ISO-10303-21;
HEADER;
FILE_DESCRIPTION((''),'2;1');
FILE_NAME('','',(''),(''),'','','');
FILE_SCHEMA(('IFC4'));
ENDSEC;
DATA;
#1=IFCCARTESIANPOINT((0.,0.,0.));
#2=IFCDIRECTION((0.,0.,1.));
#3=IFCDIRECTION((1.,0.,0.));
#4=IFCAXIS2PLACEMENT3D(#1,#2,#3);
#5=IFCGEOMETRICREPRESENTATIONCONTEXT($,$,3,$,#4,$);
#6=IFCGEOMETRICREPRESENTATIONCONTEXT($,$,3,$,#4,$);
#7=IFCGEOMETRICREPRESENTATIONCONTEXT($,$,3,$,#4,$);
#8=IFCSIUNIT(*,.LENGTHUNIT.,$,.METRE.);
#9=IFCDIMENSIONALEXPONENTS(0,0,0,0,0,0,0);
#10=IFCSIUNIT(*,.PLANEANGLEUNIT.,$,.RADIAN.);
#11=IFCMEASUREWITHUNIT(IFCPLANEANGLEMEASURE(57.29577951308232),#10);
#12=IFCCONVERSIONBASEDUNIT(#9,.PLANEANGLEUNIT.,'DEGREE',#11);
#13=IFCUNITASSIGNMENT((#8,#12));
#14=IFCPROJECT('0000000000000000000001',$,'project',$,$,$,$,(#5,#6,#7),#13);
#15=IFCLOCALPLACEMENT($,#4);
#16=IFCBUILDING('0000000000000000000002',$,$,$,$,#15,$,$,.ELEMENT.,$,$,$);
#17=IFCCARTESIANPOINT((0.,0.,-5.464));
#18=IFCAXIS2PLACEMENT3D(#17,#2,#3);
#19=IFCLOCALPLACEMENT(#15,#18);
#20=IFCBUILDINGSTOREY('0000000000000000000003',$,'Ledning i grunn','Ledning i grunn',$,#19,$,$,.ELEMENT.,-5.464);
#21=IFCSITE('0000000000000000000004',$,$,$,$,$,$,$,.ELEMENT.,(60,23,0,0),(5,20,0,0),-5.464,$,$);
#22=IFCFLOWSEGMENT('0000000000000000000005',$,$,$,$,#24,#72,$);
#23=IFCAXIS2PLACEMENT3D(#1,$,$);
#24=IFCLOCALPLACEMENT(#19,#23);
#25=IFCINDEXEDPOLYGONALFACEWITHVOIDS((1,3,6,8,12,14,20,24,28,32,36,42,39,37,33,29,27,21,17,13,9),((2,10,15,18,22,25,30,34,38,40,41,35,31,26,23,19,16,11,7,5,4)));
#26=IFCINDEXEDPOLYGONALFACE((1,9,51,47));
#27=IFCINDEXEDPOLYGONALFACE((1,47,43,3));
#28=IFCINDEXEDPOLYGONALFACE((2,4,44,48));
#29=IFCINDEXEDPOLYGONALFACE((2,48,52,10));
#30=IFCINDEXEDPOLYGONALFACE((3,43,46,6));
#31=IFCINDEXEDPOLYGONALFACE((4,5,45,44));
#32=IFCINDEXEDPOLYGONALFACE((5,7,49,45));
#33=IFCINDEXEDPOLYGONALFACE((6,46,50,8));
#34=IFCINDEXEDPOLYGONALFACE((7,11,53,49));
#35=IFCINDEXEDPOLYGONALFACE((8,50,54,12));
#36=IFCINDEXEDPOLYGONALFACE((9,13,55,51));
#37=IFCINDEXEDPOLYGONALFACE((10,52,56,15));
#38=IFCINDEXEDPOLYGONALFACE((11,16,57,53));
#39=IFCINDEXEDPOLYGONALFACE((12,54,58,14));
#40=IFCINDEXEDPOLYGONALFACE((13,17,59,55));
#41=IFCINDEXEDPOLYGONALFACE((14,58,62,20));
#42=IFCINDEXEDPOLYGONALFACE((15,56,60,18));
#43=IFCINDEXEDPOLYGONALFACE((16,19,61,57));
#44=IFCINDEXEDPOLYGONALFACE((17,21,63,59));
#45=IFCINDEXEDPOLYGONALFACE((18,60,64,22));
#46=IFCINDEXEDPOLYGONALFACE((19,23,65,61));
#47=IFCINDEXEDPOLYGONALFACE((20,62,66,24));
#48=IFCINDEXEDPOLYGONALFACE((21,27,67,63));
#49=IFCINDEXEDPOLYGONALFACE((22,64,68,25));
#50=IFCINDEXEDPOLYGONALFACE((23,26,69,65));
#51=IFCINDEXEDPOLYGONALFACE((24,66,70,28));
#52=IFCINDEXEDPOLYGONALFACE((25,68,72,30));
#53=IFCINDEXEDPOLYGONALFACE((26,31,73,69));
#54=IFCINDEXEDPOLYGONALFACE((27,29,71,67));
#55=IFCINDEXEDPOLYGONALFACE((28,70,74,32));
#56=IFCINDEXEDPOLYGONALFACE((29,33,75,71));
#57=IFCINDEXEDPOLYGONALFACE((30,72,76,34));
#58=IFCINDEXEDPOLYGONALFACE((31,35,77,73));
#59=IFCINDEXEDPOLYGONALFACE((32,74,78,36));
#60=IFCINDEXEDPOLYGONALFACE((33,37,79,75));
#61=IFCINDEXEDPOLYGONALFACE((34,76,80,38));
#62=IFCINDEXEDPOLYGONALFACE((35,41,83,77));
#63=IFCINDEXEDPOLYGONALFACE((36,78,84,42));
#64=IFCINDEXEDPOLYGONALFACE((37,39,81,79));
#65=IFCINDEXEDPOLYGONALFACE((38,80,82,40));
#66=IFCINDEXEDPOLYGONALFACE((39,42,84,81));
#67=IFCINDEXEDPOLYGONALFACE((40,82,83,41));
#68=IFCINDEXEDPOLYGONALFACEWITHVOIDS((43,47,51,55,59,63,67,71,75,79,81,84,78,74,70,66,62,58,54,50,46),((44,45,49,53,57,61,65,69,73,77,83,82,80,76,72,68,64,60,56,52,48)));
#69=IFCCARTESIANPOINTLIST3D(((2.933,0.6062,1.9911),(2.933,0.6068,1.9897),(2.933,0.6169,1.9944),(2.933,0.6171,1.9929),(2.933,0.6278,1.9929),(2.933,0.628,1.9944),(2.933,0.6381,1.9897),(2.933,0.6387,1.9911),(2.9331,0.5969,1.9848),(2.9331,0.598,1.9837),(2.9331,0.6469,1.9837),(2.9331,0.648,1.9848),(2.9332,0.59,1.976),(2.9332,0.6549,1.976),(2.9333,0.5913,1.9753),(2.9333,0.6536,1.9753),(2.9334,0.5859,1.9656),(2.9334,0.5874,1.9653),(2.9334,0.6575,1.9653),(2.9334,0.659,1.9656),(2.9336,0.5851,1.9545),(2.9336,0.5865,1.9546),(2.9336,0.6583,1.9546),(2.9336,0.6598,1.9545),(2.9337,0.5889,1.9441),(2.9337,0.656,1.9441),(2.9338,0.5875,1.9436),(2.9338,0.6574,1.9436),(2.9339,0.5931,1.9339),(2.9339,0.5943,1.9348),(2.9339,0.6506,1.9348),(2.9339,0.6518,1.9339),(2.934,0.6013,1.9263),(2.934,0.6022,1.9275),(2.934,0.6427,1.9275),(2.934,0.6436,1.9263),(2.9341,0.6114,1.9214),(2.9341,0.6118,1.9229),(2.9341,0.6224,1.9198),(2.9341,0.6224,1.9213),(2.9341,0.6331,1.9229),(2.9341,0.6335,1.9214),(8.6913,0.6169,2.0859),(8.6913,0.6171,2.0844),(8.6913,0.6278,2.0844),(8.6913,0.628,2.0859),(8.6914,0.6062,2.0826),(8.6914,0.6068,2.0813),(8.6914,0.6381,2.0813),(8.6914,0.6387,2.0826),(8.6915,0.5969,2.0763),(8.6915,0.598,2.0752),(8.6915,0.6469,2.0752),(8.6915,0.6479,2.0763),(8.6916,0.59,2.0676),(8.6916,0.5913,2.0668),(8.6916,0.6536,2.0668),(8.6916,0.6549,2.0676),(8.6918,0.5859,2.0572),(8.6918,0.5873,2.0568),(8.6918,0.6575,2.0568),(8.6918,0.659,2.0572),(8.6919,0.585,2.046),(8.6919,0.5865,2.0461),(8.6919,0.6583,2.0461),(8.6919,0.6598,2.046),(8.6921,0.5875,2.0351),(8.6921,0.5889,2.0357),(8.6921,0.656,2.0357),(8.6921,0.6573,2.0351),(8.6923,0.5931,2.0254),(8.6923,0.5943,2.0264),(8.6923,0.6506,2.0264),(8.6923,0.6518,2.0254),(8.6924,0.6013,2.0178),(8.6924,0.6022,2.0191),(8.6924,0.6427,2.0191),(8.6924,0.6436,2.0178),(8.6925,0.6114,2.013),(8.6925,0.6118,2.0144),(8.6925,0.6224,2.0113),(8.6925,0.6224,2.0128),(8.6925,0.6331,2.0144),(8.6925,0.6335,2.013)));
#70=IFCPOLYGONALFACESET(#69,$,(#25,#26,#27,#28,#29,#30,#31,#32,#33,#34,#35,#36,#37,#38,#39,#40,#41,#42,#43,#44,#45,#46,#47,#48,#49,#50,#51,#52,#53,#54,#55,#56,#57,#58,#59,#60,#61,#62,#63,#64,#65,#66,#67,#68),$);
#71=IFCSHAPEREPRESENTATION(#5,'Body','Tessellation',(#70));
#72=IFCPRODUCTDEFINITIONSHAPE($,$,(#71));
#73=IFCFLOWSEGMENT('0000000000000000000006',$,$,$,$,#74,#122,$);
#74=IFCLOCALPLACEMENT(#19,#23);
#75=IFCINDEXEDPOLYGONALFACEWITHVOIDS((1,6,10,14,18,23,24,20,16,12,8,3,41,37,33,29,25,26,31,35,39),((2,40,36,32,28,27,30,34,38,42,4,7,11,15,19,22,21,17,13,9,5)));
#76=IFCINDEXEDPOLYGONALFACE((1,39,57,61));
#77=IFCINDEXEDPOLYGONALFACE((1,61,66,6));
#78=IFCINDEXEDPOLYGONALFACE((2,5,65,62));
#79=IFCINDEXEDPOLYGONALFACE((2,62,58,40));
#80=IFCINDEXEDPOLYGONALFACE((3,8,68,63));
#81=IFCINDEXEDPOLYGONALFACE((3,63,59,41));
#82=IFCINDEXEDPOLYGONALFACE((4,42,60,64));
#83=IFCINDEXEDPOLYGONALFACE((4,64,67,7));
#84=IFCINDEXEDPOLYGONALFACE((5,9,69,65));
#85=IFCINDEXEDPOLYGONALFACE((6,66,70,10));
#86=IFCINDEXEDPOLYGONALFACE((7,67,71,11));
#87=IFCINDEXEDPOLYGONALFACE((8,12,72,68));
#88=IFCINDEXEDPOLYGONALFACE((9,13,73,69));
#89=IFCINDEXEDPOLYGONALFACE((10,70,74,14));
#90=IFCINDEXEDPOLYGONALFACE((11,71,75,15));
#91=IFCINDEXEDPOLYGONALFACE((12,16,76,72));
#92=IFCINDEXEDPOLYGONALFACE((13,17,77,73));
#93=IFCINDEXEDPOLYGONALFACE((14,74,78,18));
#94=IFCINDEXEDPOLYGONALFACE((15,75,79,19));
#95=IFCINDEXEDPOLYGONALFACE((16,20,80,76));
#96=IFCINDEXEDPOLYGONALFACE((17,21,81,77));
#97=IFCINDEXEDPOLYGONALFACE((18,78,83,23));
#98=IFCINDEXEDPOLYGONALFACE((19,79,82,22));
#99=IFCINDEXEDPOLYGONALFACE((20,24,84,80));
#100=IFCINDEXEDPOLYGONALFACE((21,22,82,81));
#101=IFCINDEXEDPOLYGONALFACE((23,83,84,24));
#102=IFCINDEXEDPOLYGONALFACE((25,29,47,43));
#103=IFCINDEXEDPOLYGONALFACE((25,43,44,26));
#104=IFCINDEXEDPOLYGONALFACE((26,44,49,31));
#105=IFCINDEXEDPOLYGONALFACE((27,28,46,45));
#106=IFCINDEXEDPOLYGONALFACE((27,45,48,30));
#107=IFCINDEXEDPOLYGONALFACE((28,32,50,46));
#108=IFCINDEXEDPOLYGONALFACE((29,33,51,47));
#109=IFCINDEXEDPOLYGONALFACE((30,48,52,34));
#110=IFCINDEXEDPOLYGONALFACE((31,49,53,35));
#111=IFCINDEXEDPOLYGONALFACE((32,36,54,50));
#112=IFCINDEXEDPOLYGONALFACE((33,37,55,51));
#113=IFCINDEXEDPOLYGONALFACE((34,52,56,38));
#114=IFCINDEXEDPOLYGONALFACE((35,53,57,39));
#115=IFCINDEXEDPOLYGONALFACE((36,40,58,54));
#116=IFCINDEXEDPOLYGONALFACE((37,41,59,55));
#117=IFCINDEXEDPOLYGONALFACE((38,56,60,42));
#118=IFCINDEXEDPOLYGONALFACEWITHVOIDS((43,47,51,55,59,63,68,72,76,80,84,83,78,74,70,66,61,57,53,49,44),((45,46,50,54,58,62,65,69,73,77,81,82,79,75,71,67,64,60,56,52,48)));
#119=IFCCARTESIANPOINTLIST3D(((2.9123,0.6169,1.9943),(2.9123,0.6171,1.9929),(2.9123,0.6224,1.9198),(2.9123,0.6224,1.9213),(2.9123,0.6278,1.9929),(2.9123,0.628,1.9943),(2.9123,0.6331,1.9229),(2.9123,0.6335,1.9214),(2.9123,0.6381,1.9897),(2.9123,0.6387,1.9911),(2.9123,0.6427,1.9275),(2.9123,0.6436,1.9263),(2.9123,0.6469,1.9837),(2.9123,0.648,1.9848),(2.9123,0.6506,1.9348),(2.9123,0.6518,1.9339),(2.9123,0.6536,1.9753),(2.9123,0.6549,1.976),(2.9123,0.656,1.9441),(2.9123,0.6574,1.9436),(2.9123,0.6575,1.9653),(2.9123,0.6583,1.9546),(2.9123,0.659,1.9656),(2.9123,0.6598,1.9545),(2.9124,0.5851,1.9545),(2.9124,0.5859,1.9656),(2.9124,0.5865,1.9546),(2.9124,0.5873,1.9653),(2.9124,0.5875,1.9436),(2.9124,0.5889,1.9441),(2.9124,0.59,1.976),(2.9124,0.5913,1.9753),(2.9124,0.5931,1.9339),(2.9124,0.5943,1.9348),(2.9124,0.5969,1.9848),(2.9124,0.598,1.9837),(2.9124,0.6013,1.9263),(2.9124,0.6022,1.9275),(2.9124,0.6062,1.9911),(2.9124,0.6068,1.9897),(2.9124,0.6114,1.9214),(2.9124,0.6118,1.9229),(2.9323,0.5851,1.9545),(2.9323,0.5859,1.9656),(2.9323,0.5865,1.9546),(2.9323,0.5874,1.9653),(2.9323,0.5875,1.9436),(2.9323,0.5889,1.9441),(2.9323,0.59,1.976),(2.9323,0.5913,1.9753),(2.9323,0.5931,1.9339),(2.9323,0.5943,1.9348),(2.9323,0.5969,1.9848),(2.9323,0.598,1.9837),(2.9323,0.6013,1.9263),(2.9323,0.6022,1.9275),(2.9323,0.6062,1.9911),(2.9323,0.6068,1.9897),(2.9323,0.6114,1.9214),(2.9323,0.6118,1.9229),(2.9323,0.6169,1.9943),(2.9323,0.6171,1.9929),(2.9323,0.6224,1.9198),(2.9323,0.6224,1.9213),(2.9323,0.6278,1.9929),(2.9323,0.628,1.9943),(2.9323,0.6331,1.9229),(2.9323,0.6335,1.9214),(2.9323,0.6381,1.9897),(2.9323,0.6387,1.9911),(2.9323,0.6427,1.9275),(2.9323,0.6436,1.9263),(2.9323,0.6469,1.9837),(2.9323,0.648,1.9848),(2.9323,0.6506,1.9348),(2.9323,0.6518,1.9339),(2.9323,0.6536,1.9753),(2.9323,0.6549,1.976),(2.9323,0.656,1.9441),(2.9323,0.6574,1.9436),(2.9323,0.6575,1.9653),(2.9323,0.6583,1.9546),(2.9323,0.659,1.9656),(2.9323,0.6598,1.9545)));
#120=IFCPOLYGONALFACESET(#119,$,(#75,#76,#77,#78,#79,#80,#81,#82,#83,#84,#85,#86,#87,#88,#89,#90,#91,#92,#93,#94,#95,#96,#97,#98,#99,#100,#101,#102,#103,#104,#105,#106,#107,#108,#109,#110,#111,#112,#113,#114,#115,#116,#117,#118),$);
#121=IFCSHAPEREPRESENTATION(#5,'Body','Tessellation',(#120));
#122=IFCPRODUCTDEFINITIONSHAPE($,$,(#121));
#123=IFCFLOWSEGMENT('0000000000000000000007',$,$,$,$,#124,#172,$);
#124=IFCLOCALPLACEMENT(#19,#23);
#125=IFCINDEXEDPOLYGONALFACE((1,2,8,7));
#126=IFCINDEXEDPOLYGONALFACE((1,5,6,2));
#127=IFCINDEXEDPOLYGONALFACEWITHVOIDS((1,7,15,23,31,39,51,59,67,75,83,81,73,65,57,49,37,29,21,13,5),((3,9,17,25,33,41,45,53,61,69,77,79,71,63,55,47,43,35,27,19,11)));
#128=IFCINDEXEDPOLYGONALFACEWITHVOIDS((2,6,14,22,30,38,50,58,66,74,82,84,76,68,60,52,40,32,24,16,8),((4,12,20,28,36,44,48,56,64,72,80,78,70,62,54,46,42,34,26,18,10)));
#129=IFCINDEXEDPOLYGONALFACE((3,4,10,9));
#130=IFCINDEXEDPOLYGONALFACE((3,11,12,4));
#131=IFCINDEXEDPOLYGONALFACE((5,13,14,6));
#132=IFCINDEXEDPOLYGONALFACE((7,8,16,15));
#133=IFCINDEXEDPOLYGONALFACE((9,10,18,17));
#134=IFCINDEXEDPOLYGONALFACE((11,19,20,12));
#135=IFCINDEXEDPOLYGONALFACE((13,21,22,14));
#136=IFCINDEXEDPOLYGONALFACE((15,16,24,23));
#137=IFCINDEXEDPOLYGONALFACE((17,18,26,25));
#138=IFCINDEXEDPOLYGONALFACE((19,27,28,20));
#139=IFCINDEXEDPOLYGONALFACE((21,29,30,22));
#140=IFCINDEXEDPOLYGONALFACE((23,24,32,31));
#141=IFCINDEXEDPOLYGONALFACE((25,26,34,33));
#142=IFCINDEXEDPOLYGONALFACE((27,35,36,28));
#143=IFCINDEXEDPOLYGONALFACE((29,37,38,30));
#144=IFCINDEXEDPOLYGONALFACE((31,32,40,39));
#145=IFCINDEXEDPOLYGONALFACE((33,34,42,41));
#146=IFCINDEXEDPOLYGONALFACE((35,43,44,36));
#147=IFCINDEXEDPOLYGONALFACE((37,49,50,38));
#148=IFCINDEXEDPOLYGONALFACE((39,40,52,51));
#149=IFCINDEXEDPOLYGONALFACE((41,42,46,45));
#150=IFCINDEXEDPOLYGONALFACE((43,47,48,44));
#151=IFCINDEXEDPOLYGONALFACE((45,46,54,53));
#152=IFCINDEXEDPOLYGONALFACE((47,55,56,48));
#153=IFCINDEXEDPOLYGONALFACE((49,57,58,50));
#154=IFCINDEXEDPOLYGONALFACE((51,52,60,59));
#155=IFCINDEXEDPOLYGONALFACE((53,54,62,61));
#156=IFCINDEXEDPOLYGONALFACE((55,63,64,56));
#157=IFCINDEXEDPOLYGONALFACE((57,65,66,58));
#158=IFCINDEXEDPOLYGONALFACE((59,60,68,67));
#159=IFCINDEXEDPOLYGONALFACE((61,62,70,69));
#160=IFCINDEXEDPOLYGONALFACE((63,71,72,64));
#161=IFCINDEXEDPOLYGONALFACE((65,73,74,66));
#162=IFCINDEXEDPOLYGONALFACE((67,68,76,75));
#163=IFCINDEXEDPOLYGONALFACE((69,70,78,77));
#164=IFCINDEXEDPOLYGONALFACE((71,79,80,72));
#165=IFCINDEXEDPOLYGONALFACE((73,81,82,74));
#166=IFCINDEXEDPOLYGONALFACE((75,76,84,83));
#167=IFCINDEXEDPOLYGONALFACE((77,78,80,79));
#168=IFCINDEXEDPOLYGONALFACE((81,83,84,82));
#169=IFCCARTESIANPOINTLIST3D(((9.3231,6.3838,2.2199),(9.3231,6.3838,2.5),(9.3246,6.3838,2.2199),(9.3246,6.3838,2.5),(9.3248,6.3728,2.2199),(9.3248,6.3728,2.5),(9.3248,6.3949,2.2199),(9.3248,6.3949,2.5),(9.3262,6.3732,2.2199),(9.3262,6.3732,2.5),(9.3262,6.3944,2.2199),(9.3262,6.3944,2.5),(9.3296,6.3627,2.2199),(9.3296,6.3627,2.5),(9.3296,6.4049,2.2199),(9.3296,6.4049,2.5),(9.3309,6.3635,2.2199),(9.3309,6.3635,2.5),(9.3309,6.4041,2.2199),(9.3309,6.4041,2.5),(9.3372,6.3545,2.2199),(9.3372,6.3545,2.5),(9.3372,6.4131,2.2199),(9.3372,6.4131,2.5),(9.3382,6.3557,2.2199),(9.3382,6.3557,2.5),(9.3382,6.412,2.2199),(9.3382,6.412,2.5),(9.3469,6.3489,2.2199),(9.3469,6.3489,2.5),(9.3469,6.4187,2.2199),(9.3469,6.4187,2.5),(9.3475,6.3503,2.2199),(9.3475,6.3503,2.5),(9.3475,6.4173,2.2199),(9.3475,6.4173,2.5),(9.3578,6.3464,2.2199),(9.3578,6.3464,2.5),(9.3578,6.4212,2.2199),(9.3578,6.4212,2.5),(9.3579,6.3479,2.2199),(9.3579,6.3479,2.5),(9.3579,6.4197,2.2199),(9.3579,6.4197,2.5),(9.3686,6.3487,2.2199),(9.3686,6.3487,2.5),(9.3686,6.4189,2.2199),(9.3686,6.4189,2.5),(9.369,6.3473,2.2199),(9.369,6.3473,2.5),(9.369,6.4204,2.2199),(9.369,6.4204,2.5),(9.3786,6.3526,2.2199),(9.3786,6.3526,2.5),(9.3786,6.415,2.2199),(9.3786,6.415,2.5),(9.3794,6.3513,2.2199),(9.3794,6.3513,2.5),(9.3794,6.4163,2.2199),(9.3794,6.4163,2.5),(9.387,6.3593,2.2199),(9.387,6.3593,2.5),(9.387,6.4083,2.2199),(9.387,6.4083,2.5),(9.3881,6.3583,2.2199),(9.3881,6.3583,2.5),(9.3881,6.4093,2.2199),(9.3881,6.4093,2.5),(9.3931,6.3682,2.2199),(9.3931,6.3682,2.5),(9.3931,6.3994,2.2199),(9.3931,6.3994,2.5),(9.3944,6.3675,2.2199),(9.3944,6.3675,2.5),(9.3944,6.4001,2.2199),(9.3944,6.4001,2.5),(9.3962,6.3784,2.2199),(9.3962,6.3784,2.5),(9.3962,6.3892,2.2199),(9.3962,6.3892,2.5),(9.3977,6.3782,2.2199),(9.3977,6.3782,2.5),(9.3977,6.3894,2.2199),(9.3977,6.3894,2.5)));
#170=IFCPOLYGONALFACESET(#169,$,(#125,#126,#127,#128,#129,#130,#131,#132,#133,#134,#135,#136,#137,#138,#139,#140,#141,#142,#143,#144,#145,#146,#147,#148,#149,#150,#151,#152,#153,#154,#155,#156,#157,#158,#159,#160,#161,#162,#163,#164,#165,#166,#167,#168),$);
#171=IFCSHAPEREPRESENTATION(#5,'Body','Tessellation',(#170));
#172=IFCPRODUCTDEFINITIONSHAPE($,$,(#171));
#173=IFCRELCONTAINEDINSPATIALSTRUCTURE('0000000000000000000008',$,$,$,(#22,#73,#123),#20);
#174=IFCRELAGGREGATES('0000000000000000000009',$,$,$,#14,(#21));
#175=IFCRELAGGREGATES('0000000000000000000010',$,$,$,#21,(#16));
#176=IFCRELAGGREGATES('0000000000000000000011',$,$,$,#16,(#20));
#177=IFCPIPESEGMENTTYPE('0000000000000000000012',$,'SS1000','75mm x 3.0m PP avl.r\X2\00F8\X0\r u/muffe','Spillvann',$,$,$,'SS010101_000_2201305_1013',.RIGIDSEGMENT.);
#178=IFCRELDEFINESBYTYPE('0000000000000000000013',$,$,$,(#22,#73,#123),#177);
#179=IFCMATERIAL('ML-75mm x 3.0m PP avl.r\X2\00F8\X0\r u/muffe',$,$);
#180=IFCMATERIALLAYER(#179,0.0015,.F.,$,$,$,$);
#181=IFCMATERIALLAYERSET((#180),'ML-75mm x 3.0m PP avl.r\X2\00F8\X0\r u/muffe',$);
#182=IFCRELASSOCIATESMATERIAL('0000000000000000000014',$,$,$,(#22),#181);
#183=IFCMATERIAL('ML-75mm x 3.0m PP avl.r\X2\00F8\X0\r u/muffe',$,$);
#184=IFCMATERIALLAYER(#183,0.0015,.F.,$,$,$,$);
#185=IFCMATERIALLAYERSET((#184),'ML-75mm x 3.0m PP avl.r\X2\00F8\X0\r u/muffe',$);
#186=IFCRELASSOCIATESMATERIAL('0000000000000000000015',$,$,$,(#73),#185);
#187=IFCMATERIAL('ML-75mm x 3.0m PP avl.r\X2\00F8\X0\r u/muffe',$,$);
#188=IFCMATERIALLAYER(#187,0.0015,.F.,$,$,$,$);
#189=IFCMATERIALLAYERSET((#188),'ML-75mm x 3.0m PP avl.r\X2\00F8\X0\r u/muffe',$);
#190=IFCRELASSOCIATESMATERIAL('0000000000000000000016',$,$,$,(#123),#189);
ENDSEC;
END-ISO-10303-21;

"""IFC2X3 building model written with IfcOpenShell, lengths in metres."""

from ifc_helpers import new_model, entity, si_unit, converted_unit, frame, origin_with_axes, origin_2d_with_axis, place, context, project, spatial, hollow_circle, extrude, material, layer, layer_set, layer_usage, type_object, element, save


model = new_model("IFC2X3")

# Units and contexts
context_of_model_1 = context(None, 3, world=origin_with_axes())
context_of_model_2 = context(None, 3, world=origin_with_axes())
context_of_model_3 = context(None, 3, world=origin_with_axes())
ifc_project = project(units=[si_unit("LENGTHUNIT", "METRE"), converted_unit("PLANEANGLEUNIT", "DEGREE", entity("IfcPlaneAngleMeasure", 57.29577951308232), si_unit("PLANEANGLEUNIT", "RADIAN"), dimensions=[0, 0, 0, 0, 0, 0, 0])], contexts=[context_of_model_1, context_of_model_2, context_of_model_3])

# Site, building, storey
site = spatial("IfcSite", under=ifc_project, CompositionType="ELEMENT", RefLatitude=(60, 23, 0, 0), RefLongitude=(5, 20, 0, 0), RefElevation=-5.464)
building_placement = place(None, origin_with_axes())
building = spatial("IfcBuilding", under=site, at=building_placement, CompositionType="ELEMENT")
storey_placement = place(building_placement, frame((0.0, 0.0, -5.464), z_axis=(0.0, 0.0, 1.0), x_axis=(1.0, 0.0, 0.0)))
storey = spatial("IfcBuildingStorey", under=building, at=storey_placement, Name="Ledning i grunn", Description="Ledning i grunn", CompositionType="ELEMENT", Elevation=-5.464)

# Flow segments
pipe_segment_type_1 = type_object("IfcPipeSegmentType", Name="SS1000", Description="75mm x 3.0m PP avl.rør u/muffe", ApplicableOccurrence="Spillvann", ElementType="SS010101_000_2201305_1013", PredefinedType="RIGIDSEGMENT")
ifc_material_1 = material(Name="ML-75mm x 3.0m PP avl.rør u/muffe")
ifc_layer_1 = layer(ifc_material_1, 0.0015, ventilated=False)
ifc_layer_set_1 = layer_set([ifc_layer_1], Name="ML-75mm x 3.0m PP avl.rør u/muffe")
ifc_layer_usage_1 = layer_usage(ifc_layer_set_1, "AXIS2", "POSITIVE", 0.0)
flow_segment_1_placement = place(storey_placement, frame((8.6919, 0.6224, 2.0488), z_axis=(-0.999874, 0.000001, -0.015896), x_axis=(0.015896, 0.0, -0.999874)))
element("IfcFlowSegment", 1, at=flow_segment_1_placement, inside=storey, type_object=pipe_segment_type_1, material=ifc_layer_usage_1, context=context_of_model_1, shape_type="SweptSolid", body=[
    extrude(hollow_circle(Radius=0.0375, WallThickness=0.0015, at=origin_2d_with_axis()), origin_with_axes(), (0.0, 0.0, 1.0), 5.7591),
])
ifc_material_2 = material(Name="ML-75mm x 3.0m PP avl.rør u/muffe")
ifc_layer_2 = layer(ifc_material_2, 0.0015, ventilated=False)
ifc_layer_set_2 = layer_set([ifc_layer_2], Name="ML-75mm x 3.0m PP avl.rør u/muffe")
ifc_layer_usage_2 = layer_usage(ifc_layer_set_2, "AXIS2", "POSITIVE", 0.0)
flow_segment_2_placement = place(storey_placement, frame((2.9323, 0.6224, 1.9573), z_axis=(-1.0, -0.000057, 0.0), x_axis=(0.0, 0.0, -1.0)))
element("IfcFlowSegment", 2, at=flow_segment_2_placement, inside=storey, type_object=pipe_segment_type_1, material=ifc_layer_usage_2, context=context_of_model_1, shape_type="SweptSolid", body=[
    extrude(hollow_circle(Radius=0.0375, WallThickness=0.0015, at=origin_2d_with_axis()), origin_with_axes(), (0.0, 0.0, 1.0), 0.02),
])
ifc_material_3 = material(Name="ML-75mm x 3.0m PP avl.rør u/muffe")
ifc_layer_3 = layer(ifc_material_3, 0.0015, ventilated=False)
ifc_layer_set_3 = layer_set([ifc_layer_3], Name="ML-75mm x 3.0m PP avl.rør u/muffe")
ifc_layer_usage_3 = layer_usage(ifc_layer_set_3, "AXIS2", "POSITIVE", 0.0)
flow_segment_3_placement = place(storey_placement, frame((9.3606, 6.3838, 2.5), z_axis=(0.0, 0.0, -1.0), x_axis=(-1.0, 0.0, 0.0)))
element("IfcFlowSegment", 3, at=flow_segment_3_placement, inside=storey, type_object=pipe_segment_type_1, material=ifc_layer_usage_3, context=context_of_model_1, shape_type="SweptSolid", body=[
    extrude(hollow_circle(Radius=0.0375, WallThickness=0.0015, at=origin_2d_with_axis()), origin_with_axes(), (0.0, 0.0, 1.0), 0.2801),
])

save(model, "model.ifc")
